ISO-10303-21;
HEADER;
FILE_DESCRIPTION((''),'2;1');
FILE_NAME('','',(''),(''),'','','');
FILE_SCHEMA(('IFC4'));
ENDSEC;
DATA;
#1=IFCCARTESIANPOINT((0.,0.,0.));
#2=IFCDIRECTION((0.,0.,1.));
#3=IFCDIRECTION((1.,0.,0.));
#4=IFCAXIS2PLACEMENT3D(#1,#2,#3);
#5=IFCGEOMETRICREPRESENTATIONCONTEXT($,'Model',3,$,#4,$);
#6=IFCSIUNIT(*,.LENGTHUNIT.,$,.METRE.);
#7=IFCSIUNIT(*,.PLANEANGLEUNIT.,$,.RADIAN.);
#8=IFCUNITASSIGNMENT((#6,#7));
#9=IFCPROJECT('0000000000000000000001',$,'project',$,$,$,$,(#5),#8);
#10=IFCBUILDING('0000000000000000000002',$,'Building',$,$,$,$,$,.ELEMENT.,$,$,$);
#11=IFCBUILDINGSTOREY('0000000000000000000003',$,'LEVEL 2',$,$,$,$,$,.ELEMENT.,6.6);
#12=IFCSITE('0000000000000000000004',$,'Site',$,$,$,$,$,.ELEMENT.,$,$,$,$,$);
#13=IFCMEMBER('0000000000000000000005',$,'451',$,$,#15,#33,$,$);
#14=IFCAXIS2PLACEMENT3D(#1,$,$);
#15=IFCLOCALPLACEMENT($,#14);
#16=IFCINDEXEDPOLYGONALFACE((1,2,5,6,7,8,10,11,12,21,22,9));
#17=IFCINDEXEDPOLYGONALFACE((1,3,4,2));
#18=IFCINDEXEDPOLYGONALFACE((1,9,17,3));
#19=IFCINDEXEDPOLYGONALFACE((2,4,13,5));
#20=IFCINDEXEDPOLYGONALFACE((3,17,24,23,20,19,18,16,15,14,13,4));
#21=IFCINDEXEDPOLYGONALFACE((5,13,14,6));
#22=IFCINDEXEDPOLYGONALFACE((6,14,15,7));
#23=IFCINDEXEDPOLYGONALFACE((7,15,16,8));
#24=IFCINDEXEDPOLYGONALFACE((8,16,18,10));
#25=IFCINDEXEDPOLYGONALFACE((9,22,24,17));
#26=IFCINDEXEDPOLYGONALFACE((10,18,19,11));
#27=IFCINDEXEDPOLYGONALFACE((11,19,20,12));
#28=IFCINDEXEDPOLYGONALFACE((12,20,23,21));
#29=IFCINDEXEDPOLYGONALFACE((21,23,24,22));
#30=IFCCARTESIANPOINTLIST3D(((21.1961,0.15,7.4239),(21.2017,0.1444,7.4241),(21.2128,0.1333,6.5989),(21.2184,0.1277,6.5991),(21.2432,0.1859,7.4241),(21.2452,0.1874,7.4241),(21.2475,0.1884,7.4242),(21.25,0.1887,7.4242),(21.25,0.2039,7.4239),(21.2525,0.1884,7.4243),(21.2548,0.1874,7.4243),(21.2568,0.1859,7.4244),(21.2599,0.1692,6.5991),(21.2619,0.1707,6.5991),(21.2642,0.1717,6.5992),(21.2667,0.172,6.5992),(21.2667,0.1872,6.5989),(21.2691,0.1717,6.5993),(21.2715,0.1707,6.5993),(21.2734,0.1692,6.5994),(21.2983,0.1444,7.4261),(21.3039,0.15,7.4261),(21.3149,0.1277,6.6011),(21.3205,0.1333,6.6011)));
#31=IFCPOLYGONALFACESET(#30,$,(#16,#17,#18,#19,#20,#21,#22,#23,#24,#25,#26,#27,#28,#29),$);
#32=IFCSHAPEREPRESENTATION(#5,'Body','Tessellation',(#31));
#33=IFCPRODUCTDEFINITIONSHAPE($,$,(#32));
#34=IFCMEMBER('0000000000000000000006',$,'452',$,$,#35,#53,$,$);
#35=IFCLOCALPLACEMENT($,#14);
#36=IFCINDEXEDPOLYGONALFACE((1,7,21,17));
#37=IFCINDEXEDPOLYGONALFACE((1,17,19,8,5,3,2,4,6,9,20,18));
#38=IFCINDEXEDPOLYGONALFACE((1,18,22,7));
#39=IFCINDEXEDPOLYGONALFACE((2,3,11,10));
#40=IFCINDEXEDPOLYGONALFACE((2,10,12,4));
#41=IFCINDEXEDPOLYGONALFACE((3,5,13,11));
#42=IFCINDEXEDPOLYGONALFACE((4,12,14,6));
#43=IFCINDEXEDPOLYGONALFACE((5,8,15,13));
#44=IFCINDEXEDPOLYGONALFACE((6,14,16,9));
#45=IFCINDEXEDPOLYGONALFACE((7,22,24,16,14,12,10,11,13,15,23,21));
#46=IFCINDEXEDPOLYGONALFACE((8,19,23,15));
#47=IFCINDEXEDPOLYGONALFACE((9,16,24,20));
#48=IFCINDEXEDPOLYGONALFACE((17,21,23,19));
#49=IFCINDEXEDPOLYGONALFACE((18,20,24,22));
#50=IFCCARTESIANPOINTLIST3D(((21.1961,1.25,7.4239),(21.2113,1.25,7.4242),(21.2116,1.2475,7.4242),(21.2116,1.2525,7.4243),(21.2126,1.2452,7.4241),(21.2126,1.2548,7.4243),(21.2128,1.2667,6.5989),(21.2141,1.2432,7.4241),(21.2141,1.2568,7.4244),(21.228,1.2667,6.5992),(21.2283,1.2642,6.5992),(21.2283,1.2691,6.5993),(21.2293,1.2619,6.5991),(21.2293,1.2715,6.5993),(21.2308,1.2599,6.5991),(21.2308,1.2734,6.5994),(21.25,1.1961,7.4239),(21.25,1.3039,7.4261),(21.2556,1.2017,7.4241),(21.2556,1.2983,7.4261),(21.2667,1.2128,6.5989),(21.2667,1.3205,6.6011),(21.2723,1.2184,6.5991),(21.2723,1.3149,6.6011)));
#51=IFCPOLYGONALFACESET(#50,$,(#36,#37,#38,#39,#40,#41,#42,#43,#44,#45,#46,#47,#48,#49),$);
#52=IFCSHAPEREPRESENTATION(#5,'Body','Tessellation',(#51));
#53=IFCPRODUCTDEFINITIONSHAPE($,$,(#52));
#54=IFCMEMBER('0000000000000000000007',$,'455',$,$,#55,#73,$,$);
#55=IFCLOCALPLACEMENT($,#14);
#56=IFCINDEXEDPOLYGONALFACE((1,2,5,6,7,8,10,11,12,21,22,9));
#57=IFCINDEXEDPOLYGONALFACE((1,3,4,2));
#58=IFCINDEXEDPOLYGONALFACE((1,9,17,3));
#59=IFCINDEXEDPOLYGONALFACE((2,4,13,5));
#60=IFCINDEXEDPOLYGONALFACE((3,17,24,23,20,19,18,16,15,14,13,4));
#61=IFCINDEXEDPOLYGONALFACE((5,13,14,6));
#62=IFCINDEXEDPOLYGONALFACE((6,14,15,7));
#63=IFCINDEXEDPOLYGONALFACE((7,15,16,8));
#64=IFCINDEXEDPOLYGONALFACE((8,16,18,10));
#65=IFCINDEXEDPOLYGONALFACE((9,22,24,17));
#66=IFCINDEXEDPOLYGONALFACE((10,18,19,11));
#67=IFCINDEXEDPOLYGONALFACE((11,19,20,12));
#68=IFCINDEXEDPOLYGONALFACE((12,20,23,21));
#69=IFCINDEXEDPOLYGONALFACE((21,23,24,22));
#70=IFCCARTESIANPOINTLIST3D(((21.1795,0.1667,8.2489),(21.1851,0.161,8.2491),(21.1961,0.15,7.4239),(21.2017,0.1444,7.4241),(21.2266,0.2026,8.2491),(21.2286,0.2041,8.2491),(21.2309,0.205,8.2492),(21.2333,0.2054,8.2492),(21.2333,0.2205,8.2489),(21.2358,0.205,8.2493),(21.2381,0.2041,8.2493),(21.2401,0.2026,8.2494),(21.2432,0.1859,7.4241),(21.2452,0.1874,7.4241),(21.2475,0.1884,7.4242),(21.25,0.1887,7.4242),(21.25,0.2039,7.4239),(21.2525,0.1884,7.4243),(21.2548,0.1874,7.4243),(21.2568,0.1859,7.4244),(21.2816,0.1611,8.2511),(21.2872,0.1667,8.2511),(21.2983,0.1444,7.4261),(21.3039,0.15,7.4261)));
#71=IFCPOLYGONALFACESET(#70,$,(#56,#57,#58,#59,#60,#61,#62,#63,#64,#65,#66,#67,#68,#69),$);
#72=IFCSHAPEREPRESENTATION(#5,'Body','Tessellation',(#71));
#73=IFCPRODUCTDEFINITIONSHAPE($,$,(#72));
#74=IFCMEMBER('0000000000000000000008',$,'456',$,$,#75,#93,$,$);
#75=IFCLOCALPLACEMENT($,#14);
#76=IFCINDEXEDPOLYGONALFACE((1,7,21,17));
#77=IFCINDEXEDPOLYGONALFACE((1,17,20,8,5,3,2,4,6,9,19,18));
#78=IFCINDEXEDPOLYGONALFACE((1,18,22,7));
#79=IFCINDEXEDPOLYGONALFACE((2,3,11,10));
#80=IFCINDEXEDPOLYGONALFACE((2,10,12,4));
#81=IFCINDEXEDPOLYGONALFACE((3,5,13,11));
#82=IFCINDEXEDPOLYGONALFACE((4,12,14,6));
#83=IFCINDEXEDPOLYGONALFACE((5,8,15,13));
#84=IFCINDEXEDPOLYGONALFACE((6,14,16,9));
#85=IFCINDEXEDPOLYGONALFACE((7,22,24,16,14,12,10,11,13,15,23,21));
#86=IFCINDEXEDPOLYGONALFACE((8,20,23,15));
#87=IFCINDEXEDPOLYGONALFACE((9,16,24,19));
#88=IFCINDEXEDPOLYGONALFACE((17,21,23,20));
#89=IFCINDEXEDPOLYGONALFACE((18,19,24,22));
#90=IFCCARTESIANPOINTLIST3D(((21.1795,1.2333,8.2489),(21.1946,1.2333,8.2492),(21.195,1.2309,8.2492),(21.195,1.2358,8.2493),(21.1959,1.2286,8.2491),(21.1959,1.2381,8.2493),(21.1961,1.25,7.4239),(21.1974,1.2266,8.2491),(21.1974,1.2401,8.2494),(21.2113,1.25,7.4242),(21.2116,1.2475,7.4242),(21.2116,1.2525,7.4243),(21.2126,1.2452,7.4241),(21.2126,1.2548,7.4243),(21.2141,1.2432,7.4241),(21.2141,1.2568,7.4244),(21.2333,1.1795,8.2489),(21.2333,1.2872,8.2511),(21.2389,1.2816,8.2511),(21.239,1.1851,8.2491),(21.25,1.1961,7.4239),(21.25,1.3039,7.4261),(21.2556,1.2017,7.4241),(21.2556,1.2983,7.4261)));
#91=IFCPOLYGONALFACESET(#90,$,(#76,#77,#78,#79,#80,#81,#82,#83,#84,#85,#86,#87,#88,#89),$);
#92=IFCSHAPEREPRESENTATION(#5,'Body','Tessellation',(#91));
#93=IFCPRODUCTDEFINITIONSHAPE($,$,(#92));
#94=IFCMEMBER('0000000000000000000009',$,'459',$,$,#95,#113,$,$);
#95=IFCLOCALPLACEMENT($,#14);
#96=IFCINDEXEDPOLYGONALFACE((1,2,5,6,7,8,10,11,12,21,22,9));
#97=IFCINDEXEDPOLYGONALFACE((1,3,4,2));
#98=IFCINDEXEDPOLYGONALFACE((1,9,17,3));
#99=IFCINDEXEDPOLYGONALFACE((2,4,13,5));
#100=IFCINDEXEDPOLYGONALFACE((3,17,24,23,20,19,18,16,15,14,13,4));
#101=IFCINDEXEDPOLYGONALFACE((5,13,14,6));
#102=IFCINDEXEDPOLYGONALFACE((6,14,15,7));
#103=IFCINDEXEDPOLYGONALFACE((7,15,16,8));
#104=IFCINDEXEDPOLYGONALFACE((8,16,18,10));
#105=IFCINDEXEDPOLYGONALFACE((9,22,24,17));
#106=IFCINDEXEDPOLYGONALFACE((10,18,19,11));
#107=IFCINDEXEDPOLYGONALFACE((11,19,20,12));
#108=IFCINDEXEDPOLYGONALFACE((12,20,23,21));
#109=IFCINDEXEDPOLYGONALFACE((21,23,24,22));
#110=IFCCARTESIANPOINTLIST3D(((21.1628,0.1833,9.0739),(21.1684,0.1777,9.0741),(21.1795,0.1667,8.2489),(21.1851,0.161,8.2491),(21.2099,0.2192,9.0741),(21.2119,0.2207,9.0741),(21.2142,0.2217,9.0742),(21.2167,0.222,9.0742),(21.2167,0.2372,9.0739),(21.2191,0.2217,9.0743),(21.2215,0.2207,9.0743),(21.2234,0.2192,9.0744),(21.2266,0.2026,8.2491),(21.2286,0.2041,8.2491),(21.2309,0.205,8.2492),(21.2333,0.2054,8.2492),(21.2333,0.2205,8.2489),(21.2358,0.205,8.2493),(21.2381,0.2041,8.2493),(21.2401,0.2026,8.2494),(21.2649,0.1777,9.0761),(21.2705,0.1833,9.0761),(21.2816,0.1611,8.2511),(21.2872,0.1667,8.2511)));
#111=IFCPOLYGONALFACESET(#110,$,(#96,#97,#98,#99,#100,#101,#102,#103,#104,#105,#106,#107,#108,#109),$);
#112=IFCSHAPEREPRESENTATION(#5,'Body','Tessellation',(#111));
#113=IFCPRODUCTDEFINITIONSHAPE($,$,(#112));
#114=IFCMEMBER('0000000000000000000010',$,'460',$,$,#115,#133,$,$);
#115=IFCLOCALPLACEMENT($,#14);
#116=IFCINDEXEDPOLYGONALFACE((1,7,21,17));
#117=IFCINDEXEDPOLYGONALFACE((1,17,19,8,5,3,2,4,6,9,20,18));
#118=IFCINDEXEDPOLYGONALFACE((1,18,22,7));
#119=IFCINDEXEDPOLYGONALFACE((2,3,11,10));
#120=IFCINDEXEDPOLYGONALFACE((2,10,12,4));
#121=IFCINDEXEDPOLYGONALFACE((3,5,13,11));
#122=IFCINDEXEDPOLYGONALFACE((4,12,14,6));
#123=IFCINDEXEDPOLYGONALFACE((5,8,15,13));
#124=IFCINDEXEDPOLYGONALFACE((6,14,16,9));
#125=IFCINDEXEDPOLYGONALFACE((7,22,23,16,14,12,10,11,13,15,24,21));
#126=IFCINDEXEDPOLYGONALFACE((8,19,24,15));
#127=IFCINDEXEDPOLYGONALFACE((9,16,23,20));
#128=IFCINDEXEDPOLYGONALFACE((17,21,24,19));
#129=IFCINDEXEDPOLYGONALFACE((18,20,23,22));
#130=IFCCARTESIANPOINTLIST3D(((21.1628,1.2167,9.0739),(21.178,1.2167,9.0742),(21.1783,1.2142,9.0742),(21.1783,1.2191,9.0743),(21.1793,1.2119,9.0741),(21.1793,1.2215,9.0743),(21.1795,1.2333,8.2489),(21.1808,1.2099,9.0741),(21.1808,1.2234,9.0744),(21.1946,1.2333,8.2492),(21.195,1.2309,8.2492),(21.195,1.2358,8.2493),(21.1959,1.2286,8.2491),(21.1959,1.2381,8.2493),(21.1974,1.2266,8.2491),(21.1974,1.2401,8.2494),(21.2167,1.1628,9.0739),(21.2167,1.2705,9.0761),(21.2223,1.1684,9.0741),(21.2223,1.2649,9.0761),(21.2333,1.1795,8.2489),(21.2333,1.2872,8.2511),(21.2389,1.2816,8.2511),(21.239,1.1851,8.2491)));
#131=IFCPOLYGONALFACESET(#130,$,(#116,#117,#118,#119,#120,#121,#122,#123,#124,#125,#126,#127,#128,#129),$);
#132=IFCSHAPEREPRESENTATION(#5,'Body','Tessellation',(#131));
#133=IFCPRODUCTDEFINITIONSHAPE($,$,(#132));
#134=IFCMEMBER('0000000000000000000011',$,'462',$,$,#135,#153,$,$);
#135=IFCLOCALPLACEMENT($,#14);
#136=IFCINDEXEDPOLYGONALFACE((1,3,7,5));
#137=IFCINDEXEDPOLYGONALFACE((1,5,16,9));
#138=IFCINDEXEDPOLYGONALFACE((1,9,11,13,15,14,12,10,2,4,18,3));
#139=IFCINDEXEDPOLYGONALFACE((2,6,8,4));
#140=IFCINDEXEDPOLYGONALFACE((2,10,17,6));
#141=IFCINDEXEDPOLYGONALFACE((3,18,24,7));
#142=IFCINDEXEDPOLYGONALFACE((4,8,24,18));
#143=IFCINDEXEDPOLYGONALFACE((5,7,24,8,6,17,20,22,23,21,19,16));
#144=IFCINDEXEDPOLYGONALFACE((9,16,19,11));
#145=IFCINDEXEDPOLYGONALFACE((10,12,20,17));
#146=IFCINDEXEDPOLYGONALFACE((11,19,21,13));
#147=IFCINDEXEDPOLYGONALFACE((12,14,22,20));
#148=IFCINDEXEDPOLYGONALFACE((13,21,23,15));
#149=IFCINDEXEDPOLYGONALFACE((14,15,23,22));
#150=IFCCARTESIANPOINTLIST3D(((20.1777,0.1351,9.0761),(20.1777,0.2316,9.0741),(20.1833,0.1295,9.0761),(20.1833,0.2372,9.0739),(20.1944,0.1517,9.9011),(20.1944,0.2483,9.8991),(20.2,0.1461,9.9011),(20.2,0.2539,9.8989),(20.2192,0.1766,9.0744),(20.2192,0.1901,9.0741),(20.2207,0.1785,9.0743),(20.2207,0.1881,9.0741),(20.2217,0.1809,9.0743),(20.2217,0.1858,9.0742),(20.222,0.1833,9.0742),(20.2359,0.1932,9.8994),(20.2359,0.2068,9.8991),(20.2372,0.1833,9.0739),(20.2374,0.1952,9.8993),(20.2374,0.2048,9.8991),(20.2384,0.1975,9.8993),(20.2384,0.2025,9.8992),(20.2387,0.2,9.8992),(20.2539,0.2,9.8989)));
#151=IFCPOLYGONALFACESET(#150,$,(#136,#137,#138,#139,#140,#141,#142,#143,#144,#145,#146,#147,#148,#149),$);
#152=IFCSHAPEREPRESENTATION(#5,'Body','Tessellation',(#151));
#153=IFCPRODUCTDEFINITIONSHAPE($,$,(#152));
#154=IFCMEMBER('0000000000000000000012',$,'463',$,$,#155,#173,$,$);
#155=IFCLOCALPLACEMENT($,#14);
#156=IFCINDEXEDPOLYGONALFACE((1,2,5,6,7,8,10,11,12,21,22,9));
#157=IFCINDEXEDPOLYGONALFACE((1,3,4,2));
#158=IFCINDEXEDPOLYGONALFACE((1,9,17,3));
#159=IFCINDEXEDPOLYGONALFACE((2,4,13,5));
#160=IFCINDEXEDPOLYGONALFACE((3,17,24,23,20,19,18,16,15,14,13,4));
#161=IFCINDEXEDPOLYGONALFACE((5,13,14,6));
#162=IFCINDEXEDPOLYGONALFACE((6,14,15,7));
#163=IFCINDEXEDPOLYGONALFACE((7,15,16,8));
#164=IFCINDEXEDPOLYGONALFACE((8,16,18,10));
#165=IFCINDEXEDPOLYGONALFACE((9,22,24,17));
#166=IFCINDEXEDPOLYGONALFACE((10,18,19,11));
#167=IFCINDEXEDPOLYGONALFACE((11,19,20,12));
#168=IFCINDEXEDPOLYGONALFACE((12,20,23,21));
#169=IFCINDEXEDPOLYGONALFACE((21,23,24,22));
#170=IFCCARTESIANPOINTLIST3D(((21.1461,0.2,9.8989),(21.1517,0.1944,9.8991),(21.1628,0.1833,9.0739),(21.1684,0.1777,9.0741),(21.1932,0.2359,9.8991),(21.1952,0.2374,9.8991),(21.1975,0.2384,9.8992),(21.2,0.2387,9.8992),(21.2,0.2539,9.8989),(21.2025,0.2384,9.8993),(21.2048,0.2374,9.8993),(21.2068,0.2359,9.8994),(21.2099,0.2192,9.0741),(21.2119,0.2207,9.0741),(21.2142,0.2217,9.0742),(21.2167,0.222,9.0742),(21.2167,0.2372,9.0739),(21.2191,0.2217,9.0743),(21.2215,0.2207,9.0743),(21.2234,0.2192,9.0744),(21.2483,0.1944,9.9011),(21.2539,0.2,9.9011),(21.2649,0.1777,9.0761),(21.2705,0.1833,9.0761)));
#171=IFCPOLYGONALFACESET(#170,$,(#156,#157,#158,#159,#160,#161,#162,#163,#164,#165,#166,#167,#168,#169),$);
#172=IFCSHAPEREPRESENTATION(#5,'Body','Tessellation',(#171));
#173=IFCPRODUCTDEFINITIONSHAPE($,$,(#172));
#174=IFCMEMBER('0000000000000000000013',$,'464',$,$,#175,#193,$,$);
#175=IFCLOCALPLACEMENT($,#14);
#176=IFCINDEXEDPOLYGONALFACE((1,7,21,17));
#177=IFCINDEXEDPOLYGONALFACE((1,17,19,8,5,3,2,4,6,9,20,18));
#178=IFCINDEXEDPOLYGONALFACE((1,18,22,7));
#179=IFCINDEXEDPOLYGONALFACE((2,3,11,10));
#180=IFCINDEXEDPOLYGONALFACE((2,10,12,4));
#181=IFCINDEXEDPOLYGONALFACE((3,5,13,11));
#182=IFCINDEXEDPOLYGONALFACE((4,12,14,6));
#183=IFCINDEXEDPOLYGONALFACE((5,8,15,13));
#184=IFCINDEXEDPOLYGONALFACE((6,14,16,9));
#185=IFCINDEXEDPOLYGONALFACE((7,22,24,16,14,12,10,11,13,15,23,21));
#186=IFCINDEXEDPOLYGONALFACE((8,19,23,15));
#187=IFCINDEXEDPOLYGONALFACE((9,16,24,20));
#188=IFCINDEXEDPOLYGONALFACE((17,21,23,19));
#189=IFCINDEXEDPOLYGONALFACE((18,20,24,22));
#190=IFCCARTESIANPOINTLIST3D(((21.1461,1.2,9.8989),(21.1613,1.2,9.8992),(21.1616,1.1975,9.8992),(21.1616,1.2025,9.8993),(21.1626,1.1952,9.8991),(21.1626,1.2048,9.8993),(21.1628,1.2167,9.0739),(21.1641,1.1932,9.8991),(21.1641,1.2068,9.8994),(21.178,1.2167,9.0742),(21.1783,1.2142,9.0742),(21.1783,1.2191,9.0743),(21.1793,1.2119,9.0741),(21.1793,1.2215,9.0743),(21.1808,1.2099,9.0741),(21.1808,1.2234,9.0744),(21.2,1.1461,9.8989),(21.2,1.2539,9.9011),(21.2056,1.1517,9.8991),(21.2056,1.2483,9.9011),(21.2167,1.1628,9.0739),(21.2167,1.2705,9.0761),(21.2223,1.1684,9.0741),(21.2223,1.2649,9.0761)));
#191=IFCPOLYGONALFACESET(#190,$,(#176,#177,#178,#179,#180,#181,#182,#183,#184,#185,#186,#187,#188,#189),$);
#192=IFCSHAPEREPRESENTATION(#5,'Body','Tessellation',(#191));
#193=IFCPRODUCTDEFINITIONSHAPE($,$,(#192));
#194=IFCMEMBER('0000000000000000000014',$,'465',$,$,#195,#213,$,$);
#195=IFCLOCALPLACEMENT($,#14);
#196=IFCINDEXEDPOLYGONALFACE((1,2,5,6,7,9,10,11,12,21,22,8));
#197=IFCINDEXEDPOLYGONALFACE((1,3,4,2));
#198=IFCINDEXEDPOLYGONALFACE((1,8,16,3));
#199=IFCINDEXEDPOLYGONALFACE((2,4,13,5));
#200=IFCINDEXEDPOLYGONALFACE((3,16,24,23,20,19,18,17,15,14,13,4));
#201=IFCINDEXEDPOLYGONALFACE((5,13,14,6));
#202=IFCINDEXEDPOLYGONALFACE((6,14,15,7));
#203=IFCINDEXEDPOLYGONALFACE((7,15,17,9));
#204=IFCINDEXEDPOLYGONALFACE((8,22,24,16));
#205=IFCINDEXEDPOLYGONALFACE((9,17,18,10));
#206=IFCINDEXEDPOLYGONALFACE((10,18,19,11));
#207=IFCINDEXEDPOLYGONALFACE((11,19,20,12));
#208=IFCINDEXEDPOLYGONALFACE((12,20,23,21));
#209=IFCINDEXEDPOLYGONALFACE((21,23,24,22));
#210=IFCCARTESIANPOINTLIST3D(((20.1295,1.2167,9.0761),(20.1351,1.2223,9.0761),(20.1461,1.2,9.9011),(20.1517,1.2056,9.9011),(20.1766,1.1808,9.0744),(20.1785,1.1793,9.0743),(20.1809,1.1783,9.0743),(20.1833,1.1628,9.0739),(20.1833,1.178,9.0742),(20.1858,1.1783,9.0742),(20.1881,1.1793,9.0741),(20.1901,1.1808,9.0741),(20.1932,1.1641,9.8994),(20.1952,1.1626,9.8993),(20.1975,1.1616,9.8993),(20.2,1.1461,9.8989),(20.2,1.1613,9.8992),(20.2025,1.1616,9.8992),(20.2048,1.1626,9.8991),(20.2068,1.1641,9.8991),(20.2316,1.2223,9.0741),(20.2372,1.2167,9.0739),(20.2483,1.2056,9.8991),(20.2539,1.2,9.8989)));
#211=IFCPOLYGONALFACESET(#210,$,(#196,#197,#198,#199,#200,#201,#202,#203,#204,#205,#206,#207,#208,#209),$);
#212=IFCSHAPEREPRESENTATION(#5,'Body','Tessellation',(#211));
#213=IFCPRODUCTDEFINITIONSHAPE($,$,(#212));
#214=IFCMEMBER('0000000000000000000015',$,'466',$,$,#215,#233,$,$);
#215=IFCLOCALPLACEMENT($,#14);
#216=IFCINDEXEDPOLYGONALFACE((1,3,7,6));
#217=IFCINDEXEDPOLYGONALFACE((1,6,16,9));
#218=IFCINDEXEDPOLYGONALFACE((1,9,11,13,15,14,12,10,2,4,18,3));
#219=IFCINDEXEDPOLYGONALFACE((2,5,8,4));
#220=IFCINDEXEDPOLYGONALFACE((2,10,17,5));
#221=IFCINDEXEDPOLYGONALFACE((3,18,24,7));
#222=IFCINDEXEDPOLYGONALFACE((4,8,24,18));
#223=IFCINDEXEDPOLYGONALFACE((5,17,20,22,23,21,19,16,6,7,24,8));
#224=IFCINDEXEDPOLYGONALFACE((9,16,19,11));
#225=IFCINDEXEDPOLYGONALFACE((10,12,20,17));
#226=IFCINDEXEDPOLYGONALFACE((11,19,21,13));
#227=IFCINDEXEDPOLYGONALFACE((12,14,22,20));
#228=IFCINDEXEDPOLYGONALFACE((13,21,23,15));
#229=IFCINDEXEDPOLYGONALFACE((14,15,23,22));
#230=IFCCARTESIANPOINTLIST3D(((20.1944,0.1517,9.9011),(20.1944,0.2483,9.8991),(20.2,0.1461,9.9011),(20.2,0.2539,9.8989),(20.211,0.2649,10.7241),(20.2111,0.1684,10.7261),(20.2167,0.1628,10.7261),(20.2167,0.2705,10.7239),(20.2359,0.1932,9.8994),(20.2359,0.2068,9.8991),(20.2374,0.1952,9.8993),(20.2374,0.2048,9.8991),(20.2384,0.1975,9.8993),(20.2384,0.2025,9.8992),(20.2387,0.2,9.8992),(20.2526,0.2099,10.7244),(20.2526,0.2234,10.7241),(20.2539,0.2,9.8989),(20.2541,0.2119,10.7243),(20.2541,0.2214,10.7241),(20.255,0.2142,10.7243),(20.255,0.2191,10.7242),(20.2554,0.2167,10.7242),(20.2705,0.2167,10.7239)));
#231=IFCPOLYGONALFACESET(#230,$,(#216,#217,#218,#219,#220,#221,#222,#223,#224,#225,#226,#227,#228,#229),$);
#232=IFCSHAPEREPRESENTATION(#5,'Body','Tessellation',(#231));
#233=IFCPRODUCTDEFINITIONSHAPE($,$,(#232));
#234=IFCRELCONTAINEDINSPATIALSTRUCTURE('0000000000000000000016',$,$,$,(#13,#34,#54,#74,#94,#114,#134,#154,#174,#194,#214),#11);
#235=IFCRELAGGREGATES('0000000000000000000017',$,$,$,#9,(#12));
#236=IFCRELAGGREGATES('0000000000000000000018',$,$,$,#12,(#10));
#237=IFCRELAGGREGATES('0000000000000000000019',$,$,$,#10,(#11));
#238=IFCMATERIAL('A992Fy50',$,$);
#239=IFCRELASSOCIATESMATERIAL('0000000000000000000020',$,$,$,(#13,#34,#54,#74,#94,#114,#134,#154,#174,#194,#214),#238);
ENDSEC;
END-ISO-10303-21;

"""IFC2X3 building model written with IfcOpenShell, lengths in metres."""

from ifc_helpers import new_model, si_unit, frame, origin_with_axes, origin_2d_with_axis, place, context, project, spatial, l_section, extrude, material, element, save


model = new_model("IFC2X3")

# Units and contexts
model_context = context("Model", 3, world=origin_with_axes())
ifc_project = project(units=[si_unit("LENGTHUNIT", "METRE"), si_unit("PLANEANGLEUNIT", "RADIAN")], contexts=[model_context])

# Site, building, storey
site = spatial("IfcSite", under=ifc_project, Name="Site", CompositionType="ELEMENT")
building = spatial("IfcBuilding", under=site, Name="Building", CompositionType="ELEMENT")
storey = spatial("IfcBuildingStorey", under=building, Name="LEVEL 2", CompositionType="ELEMENT", Elevation=6.6)

# Members
ifc_material = material(Name="A992Fy50")
for number, where, z_axis, x_axis, name in (
    (1, (21.2667, 0.1333, 6.6), (-0.020194, 0.020194, 0.999592), (-0.707107, -0.707107, 0.0), "451"),
    (2, (21.2667, 1.2667, 6.6), (-0.020194, -0.020194, 0.999592), (0.707107, -0.707107, 0.0), "452"),
    (3, (21.25, 0.15, 7.425), (-0.020194, 0.020194, 0.999592), (-0.707107, -0.707107, 0.0), "455"),
    (4, (21.25, 1.25, 7.425), (-0.020194, -0.020194, 0.999592), (0.707107, -0.707107, 0.0), "456"),
    (5, (21.2333, 0.1667, 8.25), (-0.020194, 0.020194, 0.999592), (-0.707107, -0.707107, 0.0), "459"),
    (6, (21.2333, 1.2333, 8.25), (-0.020194, -0.020194, 0.999592), (0.707107, -0.707107, 0.0), "460"),
    (7, (20.1833, 0.1833, 9.075), (0.020194, 0.020194, 0.999592), (-0.707107, 0.707107, 0.0), "462"),
    (8, (21.2167, 0.1833, 9.075), (-0.020194, 0.020194, 0.999592), (-0.707107, -0.707107, 0.0), "463"),
    (9, (21.2167, 1.2167, 9.075), (-0.020194, -0.020194, 0.999592), (0.707107, -0.707107, 0.0), "464"),
    (10, (20.1833, 1.2167, 9.075), (0.020194, -0.020194, 0.999592), (0.707107, 0.707107, 0.0), "465"),
    (11, (20.2, 0.2, 9.9), (0.020194, 0.020194, 0.999592), (-0.707107, 0.707107, 0.0), "466"),
):
    element("IfcMember", number, at=place(None, frame(where, z_axis=z_axis, x_axis=x_axis)), inside=storey, material=ifc_material, Name=name, context=model_context, shape_type="SweptSolid", body=[
        extrude(l_section(Depth=0.0762, Width=0.0762, Thickness=0.0079, FilletRadius=0.0096, at=origin_2d_with_axis()), origin_with_axes(), (0.0, 0.0, 1.0), 0.8253),
    ])

save(model, "model.ifc")
